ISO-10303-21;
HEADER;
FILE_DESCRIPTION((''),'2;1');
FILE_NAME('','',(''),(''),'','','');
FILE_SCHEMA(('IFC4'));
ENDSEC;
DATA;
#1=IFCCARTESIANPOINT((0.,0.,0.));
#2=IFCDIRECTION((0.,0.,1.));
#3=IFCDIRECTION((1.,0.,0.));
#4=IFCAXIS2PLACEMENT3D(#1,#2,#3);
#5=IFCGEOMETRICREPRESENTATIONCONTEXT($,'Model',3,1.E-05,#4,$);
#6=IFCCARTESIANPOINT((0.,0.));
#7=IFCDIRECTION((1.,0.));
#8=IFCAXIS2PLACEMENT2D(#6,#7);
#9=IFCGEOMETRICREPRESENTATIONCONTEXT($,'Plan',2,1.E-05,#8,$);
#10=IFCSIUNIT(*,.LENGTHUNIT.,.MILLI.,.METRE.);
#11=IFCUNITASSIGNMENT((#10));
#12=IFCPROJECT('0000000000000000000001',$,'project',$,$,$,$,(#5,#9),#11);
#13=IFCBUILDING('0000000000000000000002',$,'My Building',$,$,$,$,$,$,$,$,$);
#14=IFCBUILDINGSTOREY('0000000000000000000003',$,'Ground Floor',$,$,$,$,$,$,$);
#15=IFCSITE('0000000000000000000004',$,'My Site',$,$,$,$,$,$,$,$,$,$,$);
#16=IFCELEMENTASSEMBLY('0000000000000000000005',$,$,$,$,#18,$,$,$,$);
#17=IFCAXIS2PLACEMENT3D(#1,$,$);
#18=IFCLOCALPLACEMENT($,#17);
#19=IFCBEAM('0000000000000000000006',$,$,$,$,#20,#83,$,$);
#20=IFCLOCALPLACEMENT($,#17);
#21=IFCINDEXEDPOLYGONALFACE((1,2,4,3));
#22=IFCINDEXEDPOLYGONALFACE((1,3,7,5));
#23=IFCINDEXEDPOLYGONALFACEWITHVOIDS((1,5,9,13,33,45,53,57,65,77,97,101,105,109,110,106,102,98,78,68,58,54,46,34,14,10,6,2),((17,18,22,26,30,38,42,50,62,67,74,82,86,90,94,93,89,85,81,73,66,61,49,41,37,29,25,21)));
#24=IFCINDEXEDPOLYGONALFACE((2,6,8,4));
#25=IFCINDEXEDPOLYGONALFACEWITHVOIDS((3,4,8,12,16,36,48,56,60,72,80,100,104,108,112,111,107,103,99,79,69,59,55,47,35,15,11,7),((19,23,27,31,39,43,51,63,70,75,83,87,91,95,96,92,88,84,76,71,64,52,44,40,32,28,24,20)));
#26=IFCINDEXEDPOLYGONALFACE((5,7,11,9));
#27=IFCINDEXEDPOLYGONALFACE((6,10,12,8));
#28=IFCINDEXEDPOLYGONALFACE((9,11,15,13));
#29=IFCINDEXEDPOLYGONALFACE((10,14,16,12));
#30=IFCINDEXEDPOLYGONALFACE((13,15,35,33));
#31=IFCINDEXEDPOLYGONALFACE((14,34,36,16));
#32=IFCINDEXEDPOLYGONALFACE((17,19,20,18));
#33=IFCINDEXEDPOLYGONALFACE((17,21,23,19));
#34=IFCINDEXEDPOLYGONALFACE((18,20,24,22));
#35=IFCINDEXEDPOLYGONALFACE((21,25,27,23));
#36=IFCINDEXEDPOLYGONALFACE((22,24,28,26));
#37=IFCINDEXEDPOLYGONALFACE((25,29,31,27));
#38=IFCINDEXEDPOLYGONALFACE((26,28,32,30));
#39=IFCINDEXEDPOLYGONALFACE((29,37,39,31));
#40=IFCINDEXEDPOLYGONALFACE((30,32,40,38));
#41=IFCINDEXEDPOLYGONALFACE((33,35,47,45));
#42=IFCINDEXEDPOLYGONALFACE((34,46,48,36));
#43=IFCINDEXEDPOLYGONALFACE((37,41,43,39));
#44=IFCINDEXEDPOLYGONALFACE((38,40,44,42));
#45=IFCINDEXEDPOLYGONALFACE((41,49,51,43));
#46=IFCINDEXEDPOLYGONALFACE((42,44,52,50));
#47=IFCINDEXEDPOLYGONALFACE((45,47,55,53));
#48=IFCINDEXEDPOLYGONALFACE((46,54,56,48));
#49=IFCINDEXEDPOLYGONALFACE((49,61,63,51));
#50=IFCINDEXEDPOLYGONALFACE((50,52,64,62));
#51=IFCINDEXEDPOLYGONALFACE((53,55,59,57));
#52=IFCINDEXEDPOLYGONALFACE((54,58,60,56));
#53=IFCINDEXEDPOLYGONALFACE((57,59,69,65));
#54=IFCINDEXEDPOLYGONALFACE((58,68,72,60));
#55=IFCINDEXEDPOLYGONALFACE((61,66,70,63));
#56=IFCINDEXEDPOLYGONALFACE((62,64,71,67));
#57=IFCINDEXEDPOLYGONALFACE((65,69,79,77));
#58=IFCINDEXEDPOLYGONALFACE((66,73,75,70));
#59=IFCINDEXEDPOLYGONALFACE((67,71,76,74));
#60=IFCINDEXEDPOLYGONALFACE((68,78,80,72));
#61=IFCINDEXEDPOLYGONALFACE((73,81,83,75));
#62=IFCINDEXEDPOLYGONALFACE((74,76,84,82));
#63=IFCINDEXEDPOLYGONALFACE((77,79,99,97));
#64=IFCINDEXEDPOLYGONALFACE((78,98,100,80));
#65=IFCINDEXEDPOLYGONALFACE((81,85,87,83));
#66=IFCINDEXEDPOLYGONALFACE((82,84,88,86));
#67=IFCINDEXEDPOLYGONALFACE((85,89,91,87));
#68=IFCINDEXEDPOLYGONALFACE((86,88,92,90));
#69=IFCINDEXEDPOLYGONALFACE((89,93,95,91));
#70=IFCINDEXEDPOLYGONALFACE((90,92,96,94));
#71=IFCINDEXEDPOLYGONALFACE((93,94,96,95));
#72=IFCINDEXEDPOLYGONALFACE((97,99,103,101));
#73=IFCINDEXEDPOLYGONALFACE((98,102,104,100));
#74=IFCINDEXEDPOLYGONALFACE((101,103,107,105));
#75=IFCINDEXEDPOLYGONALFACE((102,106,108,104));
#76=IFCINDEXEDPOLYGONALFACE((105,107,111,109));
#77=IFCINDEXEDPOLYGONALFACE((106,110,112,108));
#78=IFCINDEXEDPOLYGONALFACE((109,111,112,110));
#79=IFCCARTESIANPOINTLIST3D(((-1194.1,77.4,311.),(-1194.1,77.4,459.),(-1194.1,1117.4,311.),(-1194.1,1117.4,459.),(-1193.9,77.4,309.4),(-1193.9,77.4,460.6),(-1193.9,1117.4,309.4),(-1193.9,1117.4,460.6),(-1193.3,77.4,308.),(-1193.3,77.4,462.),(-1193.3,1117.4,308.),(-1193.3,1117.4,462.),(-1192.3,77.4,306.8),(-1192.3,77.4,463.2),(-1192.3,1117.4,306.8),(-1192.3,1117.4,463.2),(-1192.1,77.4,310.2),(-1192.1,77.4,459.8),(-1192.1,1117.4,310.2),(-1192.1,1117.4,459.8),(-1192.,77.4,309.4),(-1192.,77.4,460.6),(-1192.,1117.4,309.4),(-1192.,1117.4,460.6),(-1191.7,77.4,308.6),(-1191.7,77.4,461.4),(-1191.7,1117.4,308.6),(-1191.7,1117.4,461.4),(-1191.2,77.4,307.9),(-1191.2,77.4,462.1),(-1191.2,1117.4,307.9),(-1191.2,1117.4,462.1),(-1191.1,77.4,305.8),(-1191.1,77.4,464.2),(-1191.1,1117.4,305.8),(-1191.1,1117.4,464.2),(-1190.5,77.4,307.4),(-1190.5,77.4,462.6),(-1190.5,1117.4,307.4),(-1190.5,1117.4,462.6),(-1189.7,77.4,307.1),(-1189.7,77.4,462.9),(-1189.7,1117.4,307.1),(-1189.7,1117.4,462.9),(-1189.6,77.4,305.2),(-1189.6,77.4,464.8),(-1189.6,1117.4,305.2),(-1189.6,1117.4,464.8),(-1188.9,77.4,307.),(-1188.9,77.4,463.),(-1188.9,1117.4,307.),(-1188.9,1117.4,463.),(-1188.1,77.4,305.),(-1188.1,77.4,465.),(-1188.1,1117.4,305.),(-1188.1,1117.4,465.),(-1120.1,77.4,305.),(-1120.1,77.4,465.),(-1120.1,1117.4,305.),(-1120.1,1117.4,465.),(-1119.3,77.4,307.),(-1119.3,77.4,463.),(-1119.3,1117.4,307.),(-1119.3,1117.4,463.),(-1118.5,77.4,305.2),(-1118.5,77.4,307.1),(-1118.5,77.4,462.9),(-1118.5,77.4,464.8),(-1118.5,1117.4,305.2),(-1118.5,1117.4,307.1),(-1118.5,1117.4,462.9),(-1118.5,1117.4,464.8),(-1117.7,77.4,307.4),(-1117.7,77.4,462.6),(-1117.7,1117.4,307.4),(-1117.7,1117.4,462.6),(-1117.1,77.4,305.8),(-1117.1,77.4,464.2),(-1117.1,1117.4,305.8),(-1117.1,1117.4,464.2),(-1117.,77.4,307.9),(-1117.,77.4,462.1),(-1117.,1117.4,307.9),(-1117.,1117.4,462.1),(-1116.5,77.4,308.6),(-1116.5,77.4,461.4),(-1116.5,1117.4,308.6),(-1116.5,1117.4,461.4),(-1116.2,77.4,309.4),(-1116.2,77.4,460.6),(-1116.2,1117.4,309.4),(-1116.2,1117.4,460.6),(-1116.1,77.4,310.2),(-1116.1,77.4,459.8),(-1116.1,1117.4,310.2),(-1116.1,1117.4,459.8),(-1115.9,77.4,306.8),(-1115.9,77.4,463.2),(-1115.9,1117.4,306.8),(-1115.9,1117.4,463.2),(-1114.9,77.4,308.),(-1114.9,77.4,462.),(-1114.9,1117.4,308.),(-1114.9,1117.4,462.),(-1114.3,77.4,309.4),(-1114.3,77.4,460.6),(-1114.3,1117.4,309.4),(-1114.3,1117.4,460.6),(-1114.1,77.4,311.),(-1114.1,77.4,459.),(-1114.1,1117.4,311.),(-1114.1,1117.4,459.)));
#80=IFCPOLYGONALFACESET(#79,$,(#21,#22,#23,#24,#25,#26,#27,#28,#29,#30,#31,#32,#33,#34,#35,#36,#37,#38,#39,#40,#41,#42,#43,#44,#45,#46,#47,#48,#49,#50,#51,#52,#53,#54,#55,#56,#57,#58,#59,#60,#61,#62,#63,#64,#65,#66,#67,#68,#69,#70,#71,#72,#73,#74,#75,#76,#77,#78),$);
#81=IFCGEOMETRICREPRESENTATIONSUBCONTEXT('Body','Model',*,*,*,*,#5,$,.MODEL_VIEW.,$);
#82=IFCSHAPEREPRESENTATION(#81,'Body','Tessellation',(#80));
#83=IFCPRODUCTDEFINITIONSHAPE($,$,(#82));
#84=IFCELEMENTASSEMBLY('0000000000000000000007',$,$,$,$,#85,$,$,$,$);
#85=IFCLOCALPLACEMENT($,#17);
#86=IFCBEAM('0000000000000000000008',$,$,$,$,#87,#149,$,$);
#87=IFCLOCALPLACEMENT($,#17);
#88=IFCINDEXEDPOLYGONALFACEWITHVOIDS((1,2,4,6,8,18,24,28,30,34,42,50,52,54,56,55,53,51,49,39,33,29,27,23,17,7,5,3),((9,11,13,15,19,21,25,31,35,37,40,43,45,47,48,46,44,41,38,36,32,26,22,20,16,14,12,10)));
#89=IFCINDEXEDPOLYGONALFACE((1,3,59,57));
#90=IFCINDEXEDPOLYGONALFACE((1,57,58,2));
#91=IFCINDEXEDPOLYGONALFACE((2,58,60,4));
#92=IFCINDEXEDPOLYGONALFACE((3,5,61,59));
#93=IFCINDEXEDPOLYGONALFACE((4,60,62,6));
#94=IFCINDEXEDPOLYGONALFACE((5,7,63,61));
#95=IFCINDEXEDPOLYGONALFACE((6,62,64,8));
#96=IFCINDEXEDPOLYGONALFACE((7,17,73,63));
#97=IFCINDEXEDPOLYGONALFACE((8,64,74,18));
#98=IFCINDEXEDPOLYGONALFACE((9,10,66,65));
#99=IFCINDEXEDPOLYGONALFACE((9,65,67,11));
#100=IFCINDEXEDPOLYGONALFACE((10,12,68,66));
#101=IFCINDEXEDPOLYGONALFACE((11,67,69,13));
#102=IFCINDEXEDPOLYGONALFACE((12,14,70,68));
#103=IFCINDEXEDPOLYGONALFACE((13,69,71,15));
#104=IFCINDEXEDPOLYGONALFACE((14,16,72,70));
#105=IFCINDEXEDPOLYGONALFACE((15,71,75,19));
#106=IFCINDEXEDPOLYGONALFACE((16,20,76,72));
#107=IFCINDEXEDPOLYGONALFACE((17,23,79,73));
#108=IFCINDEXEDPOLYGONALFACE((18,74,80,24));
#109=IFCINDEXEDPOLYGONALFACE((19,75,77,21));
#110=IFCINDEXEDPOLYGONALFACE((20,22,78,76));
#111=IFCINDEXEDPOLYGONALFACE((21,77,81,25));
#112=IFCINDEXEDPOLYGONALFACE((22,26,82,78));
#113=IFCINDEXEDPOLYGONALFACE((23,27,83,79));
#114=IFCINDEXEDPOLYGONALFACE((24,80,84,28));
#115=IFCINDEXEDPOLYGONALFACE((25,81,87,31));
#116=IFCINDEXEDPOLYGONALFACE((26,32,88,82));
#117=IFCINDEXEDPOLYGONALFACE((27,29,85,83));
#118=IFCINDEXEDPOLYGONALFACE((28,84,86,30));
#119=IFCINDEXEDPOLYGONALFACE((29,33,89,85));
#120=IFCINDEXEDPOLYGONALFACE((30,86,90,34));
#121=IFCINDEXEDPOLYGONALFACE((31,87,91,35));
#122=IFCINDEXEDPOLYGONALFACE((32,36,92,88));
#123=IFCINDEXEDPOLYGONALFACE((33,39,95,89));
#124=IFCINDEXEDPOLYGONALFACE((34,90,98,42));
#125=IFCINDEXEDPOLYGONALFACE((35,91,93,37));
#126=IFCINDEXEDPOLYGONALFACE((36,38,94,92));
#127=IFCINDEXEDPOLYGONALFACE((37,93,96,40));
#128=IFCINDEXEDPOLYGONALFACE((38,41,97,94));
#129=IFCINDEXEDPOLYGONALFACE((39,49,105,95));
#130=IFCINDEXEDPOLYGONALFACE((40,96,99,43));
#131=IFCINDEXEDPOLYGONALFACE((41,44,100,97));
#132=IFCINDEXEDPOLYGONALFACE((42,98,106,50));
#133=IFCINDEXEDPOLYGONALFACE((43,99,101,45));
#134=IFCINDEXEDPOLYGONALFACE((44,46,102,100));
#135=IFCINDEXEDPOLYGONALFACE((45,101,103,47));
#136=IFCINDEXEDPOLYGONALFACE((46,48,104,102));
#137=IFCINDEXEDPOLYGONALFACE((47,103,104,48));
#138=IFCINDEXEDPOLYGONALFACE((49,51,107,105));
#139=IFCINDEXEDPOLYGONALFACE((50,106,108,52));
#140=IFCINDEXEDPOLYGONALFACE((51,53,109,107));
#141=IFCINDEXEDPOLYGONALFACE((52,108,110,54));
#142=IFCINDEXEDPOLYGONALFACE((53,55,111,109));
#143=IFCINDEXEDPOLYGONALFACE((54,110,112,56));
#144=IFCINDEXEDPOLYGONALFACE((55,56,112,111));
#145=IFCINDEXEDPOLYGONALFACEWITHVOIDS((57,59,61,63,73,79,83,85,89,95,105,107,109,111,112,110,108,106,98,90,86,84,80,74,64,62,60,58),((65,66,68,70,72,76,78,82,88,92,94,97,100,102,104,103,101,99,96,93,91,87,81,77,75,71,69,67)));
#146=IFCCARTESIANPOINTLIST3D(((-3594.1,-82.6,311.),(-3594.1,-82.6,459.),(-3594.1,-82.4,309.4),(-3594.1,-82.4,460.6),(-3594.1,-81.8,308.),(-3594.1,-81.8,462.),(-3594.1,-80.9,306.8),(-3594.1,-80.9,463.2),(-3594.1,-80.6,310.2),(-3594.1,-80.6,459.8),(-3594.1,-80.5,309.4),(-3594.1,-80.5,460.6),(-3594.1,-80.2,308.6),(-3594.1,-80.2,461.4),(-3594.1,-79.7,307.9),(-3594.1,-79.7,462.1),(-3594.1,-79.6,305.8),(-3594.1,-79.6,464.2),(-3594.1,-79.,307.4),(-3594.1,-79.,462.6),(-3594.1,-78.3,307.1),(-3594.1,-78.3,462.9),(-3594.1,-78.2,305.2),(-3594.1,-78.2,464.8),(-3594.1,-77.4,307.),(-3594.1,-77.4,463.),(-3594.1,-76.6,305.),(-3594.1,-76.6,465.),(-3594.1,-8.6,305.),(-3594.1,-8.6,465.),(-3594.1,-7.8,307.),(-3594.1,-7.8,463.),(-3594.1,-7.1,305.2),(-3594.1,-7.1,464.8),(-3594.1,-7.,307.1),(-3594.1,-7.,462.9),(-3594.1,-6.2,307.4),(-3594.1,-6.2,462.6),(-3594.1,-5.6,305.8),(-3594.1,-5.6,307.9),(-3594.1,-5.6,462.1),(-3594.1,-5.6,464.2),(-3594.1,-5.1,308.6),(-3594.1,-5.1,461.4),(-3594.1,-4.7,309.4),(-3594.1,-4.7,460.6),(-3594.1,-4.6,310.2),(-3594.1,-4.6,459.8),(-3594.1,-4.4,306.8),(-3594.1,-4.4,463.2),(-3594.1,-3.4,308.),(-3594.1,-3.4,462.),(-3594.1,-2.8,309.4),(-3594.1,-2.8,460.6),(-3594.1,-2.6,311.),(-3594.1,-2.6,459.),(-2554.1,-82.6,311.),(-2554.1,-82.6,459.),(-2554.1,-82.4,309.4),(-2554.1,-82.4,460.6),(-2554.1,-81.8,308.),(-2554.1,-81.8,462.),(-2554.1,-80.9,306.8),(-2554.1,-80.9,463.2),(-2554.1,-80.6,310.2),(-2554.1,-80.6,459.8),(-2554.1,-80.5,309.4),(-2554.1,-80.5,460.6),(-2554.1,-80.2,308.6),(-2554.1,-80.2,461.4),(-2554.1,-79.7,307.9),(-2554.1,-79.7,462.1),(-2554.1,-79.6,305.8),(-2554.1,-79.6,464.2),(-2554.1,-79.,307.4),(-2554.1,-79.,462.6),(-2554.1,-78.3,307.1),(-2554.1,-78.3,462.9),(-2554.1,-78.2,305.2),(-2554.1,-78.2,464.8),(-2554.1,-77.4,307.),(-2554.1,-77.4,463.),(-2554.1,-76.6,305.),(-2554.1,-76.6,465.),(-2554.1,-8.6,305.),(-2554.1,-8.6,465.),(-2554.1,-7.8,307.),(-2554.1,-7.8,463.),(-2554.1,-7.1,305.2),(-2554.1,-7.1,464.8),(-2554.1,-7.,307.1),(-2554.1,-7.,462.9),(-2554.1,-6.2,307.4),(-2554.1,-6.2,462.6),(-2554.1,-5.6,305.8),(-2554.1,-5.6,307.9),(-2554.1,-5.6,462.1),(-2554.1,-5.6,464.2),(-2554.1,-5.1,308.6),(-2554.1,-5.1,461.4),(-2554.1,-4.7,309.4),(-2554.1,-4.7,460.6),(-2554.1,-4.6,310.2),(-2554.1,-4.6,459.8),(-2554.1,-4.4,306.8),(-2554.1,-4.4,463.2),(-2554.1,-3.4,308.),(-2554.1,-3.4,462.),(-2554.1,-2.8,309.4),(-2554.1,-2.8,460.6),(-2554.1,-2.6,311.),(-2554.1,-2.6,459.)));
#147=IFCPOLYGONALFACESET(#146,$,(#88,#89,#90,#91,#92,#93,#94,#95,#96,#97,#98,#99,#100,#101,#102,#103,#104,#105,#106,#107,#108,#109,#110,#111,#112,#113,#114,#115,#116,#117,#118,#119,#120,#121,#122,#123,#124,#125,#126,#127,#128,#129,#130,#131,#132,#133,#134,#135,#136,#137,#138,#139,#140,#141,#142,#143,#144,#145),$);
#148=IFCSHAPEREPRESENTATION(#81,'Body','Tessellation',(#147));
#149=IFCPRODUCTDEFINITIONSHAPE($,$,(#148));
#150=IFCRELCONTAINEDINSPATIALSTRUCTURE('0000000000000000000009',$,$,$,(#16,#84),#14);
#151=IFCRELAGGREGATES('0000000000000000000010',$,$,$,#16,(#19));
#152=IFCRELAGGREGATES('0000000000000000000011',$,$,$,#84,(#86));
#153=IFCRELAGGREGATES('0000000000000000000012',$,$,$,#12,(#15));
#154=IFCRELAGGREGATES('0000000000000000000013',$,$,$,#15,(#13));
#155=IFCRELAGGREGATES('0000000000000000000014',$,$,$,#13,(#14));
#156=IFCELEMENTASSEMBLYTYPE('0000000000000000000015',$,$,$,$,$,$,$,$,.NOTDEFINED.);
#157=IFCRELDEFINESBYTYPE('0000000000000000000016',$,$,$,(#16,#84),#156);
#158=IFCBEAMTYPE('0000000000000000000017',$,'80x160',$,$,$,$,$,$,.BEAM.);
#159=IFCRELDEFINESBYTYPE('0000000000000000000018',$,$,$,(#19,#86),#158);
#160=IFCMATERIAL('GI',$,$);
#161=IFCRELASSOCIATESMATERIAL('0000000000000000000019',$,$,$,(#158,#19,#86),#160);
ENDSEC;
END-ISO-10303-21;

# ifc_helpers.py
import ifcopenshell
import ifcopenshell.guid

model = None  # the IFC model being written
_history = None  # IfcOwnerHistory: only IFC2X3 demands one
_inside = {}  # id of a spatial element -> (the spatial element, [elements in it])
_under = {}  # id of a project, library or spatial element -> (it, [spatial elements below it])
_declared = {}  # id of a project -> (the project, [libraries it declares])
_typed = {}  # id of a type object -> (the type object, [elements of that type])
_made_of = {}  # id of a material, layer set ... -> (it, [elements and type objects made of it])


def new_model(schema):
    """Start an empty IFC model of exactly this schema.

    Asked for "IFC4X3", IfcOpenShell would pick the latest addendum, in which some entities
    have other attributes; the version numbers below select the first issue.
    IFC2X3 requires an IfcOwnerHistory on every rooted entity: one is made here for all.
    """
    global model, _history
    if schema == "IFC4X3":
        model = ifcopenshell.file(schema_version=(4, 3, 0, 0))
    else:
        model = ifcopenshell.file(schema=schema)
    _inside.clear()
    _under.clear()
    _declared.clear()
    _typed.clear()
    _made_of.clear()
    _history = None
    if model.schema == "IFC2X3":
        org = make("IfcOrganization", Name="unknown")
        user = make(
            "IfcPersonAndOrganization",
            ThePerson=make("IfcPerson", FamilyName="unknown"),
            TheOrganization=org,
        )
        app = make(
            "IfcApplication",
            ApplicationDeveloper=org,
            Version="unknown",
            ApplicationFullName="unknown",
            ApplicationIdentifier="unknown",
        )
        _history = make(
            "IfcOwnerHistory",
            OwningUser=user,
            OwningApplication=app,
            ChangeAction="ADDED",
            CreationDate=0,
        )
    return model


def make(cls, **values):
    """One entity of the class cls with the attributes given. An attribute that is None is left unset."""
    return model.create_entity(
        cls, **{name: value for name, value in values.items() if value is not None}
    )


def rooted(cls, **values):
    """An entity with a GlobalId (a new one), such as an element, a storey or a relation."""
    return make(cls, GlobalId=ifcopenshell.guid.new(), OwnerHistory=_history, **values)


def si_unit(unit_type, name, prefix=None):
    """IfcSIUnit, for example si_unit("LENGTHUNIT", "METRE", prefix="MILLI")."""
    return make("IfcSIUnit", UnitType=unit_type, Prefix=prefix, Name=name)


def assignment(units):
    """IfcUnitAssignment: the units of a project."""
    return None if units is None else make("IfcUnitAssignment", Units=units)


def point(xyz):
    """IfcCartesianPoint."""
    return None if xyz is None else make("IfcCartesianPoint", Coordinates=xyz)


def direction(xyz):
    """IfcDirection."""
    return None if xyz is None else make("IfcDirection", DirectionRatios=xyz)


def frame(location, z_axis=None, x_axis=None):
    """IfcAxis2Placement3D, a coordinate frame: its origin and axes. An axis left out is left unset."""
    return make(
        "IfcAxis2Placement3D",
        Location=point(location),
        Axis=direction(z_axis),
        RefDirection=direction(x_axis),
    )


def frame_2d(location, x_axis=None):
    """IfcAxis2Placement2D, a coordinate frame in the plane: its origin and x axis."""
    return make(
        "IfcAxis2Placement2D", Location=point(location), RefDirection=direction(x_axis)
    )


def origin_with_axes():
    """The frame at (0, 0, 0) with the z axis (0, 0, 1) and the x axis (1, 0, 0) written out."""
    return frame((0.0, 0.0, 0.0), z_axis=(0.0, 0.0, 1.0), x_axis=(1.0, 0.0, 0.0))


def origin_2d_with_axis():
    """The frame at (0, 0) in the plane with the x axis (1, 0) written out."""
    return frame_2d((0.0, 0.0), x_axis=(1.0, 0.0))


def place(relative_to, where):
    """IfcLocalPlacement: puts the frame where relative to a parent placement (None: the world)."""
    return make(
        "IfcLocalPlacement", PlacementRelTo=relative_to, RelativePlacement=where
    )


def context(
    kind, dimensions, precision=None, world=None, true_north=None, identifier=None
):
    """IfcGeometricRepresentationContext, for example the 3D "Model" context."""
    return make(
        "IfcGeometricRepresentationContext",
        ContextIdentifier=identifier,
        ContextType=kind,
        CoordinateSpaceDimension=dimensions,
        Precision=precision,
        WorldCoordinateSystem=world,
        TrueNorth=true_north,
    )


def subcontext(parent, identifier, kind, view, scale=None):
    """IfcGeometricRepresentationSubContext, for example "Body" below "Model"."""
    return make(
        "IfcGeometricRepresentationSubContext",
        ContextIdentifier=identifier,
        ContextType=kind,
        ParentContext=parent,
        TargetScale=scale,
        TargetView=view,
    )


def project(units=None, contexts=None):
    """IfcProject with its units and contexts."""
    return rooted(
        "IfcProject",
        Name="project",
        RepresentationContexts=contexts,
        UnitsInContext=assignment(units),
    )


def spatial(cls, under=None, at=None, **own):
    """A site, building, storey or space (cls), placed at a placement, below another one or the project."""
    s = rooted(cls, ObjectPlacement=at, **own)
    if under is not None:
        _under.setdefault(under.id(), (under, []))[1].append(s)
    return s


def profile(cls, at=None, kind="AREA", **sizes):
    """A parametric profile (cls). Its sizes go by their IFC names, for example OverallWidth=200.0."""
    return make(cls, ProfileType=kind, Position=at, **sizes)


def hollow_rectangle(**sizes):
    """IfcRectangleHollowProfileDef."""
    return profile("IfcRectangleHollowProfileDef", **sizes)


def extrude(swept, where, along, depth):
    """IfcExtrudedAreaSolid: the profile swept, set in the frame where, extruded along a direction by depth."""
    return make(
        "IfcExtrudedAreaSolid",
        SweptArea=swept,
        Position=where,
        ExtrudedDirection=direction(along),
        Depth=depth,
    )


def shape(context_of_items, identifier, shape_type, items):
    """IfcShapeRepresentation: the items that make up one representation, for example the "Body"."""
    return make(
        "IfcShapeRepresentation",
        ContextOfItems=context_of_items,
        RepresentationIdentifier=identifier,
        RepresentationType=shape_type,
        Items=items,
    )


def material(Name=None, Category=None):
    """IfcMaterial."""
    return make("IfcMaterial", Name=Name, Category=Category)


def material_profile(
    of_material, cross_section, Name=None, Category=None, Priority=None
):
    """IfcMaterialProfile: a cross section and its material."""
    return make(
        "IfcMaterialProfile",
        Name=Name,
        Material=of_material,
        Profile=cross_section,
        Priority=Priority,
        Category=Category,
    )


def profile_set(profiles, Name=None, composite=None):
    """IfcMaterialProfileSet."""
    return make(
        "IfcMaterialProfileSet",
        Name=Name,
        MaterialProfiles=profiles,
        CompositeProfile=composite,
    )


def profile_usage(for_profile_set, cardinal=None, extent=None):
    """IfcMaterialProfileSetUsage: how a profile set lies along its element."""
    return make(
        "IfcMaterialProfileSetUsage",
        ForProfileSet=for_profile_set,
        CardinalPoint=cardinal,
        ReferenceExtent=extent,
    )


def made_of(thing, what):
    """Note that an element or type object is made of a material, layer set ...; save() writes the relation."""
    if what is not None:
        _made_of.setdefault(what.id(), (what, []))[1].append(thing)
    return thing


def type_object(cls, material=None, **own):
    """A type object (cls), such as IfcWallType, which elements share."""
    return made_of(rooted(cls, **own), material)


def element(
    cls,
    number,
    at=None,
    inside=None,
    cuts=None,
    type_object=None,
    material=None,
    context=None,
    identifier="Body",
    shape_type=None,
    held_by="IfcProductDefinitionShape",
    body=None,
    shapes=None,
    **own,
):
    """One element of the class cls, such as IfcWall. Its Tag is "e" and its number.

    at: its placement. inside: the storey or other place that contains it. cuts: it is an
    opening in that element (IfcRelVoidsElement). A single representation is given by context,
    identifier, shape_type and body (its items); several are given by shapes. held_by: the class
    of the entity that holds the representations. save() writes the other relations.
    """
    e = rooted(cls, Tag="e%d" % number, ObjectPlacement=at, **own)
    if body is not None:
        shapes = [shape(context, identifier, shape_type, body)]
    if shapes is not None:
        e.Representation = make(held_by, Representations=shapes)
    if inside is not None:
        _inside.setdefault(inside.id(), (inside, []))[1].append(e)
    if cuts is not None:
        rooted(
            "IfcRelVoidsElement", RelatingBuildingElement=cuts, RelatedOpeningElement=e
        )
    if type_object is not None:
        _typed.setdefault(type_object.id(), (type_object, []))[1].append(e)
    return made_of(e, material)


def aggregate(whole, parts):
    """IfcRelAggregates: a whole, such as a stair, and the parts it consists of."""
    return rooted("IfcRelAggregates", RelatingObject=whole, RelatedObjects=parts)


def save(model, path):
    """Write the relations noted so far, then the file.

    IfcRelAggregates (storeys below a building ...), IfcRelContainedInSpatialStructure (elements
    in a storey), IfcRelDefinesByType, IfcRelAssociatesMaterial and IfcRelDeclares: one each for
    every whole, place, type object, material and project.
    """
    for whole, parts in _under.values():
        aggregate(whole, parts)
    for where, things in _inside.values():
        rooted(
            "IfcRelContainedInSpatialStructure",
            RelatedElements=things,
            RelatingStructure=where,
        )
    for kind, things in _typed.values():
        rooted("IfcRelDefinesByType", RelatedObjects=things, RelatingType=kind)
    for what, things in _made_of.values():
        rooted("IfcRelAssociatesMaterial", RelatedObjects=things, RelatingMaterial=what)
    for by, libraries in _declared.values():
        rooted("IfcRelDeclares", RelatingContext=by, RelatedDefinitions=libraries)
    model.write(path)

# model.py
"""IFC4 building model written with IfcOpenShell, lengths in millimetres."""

from ifc_helpers import new_model, si_unit, frame, origin_with_axes, origin_2d_with_axis, place, context, subcontext, project, spatial, hollow_rectangle, extrude, material, material_profile, profile_set, profile_usage, type_object, element, aggregate, save


model = new_model("IFC4")

# Units and contexts
model_context = context("Model", 3, precision=1e-05, world=origin_with_axes())
plan_context = context("Plan", 2, precision=1e-05, world=origin_2d_with_axis())
body_context = subcontext(model_context, "Body", "Model", "MODEL_VIEW")
ifc_project = project(units=[si_unit("LENGTHUNIT", "METRE", prefix="MILLI")], contexts=[model_context, plan_context])

# Site, building, storey
site = spatial("IfcSite", under=ifc_project, Name="My Site")
building = spatial("IfcBuilding", under=site, Name="My Building")
storey = spatial("IfcBuildingStorey", under=building, Name="Ground Floor")

# Shared definitions
ifc_material_1 = material(Name="GI")

# Element assemblies, beams
element_assembly_type_1 = type_object("IfcElementAssemblyType", PredefinedType="NOTDEFINED")
ifc_material_profile_1 = material_profile(ifc_material_1, hollow_rectangle(XDim=80.0, YDim=160.0, WallThickness=2.0, InnerFilletRadius=3.2, OuterFilletRadius=6.0))
ifc_profile_set_1 = profile_set([ifc_material_profile_1], Name="80x160 GI Rectangular Hollow")
beam_type = type_object("IfcBeamType", Name="80x160", PredefinedType="BEAM", material=ifc_profile_set_1)
assembly_1_placement = place(None, frame((-1154.1, -2.6, 385.0), z_axis=(0.0, 1.0, 0.0), x_axis=(1.0, 0.0, 0.0)))
assembly_1 = element("IfcElementAssembly", 1, at=assembly_1_placement, inside=storey, type_object=element_assembly_type_1)
ifc_profile_usage_1 = profile_usage(ifc_profile_set_1)
beam_1_placement = place(assembly_1_placement, frame((0.0, 0.0, 80.0), z_axis=(0.0, 0.0, 1.0), x_axis=(1.0, 0.0, 0.0)))
beam_1 = element("IfcBeam", 2, at=beam_1_placement, type_object=beam_type, material=ifc_profile_usage_1, context=body_context, shape_type="SweptSolid", body=[
    extrude(hollow_rectangle(XDim=80.0, YDim=160.0, WallThickness=2.0, InnerFilletRadius=3.2, OuterFilletRadius=6.0), origin_with_axes(), (0.0, 0.0, 1.0), 1040.0),
])
aggregate(assembly_1, [beam_1])
assembly_2_placement = place(None, frame((-3674.1, -42.6, 385.0), z_axis=(1.0, 0.0, 0.0), x_axis=(0.0, 1.0, 0.0)))
assembly_2 = element("IfcElementAssembly", 3, at=assembly_2_placement, inside=storey, type_object=element_assembly_type_1)
ifc_profile_usage_2 = profile_usage(ifc_profile_set_1)
beam_2_placement = place(assembly_2_placement, frame((0.0, 0.0, 80.0), z_axis=(0.0, 0.0, 1.0), x_axis=(1.0, 0.0, 0.0)))
beam_2 = element("IfcBeam", 4, at=beam_2_placement, type_object=beam_type, material=ifc_profile_usage_2, context=body_context, shape_type="SweptSolid", body=[
    extrude(hollow_rectangle(XDim=80.0, YDim=160.0, WallThickness=2.0, InnerFilletRadius=3.2, OuterFilletRadius=6.0), origin_with_axes(), (0.0, 0.0, 1.0), 1040.0),
])
aggregate(assembly_2, [beam_2])

save(model, "model.ifc")
